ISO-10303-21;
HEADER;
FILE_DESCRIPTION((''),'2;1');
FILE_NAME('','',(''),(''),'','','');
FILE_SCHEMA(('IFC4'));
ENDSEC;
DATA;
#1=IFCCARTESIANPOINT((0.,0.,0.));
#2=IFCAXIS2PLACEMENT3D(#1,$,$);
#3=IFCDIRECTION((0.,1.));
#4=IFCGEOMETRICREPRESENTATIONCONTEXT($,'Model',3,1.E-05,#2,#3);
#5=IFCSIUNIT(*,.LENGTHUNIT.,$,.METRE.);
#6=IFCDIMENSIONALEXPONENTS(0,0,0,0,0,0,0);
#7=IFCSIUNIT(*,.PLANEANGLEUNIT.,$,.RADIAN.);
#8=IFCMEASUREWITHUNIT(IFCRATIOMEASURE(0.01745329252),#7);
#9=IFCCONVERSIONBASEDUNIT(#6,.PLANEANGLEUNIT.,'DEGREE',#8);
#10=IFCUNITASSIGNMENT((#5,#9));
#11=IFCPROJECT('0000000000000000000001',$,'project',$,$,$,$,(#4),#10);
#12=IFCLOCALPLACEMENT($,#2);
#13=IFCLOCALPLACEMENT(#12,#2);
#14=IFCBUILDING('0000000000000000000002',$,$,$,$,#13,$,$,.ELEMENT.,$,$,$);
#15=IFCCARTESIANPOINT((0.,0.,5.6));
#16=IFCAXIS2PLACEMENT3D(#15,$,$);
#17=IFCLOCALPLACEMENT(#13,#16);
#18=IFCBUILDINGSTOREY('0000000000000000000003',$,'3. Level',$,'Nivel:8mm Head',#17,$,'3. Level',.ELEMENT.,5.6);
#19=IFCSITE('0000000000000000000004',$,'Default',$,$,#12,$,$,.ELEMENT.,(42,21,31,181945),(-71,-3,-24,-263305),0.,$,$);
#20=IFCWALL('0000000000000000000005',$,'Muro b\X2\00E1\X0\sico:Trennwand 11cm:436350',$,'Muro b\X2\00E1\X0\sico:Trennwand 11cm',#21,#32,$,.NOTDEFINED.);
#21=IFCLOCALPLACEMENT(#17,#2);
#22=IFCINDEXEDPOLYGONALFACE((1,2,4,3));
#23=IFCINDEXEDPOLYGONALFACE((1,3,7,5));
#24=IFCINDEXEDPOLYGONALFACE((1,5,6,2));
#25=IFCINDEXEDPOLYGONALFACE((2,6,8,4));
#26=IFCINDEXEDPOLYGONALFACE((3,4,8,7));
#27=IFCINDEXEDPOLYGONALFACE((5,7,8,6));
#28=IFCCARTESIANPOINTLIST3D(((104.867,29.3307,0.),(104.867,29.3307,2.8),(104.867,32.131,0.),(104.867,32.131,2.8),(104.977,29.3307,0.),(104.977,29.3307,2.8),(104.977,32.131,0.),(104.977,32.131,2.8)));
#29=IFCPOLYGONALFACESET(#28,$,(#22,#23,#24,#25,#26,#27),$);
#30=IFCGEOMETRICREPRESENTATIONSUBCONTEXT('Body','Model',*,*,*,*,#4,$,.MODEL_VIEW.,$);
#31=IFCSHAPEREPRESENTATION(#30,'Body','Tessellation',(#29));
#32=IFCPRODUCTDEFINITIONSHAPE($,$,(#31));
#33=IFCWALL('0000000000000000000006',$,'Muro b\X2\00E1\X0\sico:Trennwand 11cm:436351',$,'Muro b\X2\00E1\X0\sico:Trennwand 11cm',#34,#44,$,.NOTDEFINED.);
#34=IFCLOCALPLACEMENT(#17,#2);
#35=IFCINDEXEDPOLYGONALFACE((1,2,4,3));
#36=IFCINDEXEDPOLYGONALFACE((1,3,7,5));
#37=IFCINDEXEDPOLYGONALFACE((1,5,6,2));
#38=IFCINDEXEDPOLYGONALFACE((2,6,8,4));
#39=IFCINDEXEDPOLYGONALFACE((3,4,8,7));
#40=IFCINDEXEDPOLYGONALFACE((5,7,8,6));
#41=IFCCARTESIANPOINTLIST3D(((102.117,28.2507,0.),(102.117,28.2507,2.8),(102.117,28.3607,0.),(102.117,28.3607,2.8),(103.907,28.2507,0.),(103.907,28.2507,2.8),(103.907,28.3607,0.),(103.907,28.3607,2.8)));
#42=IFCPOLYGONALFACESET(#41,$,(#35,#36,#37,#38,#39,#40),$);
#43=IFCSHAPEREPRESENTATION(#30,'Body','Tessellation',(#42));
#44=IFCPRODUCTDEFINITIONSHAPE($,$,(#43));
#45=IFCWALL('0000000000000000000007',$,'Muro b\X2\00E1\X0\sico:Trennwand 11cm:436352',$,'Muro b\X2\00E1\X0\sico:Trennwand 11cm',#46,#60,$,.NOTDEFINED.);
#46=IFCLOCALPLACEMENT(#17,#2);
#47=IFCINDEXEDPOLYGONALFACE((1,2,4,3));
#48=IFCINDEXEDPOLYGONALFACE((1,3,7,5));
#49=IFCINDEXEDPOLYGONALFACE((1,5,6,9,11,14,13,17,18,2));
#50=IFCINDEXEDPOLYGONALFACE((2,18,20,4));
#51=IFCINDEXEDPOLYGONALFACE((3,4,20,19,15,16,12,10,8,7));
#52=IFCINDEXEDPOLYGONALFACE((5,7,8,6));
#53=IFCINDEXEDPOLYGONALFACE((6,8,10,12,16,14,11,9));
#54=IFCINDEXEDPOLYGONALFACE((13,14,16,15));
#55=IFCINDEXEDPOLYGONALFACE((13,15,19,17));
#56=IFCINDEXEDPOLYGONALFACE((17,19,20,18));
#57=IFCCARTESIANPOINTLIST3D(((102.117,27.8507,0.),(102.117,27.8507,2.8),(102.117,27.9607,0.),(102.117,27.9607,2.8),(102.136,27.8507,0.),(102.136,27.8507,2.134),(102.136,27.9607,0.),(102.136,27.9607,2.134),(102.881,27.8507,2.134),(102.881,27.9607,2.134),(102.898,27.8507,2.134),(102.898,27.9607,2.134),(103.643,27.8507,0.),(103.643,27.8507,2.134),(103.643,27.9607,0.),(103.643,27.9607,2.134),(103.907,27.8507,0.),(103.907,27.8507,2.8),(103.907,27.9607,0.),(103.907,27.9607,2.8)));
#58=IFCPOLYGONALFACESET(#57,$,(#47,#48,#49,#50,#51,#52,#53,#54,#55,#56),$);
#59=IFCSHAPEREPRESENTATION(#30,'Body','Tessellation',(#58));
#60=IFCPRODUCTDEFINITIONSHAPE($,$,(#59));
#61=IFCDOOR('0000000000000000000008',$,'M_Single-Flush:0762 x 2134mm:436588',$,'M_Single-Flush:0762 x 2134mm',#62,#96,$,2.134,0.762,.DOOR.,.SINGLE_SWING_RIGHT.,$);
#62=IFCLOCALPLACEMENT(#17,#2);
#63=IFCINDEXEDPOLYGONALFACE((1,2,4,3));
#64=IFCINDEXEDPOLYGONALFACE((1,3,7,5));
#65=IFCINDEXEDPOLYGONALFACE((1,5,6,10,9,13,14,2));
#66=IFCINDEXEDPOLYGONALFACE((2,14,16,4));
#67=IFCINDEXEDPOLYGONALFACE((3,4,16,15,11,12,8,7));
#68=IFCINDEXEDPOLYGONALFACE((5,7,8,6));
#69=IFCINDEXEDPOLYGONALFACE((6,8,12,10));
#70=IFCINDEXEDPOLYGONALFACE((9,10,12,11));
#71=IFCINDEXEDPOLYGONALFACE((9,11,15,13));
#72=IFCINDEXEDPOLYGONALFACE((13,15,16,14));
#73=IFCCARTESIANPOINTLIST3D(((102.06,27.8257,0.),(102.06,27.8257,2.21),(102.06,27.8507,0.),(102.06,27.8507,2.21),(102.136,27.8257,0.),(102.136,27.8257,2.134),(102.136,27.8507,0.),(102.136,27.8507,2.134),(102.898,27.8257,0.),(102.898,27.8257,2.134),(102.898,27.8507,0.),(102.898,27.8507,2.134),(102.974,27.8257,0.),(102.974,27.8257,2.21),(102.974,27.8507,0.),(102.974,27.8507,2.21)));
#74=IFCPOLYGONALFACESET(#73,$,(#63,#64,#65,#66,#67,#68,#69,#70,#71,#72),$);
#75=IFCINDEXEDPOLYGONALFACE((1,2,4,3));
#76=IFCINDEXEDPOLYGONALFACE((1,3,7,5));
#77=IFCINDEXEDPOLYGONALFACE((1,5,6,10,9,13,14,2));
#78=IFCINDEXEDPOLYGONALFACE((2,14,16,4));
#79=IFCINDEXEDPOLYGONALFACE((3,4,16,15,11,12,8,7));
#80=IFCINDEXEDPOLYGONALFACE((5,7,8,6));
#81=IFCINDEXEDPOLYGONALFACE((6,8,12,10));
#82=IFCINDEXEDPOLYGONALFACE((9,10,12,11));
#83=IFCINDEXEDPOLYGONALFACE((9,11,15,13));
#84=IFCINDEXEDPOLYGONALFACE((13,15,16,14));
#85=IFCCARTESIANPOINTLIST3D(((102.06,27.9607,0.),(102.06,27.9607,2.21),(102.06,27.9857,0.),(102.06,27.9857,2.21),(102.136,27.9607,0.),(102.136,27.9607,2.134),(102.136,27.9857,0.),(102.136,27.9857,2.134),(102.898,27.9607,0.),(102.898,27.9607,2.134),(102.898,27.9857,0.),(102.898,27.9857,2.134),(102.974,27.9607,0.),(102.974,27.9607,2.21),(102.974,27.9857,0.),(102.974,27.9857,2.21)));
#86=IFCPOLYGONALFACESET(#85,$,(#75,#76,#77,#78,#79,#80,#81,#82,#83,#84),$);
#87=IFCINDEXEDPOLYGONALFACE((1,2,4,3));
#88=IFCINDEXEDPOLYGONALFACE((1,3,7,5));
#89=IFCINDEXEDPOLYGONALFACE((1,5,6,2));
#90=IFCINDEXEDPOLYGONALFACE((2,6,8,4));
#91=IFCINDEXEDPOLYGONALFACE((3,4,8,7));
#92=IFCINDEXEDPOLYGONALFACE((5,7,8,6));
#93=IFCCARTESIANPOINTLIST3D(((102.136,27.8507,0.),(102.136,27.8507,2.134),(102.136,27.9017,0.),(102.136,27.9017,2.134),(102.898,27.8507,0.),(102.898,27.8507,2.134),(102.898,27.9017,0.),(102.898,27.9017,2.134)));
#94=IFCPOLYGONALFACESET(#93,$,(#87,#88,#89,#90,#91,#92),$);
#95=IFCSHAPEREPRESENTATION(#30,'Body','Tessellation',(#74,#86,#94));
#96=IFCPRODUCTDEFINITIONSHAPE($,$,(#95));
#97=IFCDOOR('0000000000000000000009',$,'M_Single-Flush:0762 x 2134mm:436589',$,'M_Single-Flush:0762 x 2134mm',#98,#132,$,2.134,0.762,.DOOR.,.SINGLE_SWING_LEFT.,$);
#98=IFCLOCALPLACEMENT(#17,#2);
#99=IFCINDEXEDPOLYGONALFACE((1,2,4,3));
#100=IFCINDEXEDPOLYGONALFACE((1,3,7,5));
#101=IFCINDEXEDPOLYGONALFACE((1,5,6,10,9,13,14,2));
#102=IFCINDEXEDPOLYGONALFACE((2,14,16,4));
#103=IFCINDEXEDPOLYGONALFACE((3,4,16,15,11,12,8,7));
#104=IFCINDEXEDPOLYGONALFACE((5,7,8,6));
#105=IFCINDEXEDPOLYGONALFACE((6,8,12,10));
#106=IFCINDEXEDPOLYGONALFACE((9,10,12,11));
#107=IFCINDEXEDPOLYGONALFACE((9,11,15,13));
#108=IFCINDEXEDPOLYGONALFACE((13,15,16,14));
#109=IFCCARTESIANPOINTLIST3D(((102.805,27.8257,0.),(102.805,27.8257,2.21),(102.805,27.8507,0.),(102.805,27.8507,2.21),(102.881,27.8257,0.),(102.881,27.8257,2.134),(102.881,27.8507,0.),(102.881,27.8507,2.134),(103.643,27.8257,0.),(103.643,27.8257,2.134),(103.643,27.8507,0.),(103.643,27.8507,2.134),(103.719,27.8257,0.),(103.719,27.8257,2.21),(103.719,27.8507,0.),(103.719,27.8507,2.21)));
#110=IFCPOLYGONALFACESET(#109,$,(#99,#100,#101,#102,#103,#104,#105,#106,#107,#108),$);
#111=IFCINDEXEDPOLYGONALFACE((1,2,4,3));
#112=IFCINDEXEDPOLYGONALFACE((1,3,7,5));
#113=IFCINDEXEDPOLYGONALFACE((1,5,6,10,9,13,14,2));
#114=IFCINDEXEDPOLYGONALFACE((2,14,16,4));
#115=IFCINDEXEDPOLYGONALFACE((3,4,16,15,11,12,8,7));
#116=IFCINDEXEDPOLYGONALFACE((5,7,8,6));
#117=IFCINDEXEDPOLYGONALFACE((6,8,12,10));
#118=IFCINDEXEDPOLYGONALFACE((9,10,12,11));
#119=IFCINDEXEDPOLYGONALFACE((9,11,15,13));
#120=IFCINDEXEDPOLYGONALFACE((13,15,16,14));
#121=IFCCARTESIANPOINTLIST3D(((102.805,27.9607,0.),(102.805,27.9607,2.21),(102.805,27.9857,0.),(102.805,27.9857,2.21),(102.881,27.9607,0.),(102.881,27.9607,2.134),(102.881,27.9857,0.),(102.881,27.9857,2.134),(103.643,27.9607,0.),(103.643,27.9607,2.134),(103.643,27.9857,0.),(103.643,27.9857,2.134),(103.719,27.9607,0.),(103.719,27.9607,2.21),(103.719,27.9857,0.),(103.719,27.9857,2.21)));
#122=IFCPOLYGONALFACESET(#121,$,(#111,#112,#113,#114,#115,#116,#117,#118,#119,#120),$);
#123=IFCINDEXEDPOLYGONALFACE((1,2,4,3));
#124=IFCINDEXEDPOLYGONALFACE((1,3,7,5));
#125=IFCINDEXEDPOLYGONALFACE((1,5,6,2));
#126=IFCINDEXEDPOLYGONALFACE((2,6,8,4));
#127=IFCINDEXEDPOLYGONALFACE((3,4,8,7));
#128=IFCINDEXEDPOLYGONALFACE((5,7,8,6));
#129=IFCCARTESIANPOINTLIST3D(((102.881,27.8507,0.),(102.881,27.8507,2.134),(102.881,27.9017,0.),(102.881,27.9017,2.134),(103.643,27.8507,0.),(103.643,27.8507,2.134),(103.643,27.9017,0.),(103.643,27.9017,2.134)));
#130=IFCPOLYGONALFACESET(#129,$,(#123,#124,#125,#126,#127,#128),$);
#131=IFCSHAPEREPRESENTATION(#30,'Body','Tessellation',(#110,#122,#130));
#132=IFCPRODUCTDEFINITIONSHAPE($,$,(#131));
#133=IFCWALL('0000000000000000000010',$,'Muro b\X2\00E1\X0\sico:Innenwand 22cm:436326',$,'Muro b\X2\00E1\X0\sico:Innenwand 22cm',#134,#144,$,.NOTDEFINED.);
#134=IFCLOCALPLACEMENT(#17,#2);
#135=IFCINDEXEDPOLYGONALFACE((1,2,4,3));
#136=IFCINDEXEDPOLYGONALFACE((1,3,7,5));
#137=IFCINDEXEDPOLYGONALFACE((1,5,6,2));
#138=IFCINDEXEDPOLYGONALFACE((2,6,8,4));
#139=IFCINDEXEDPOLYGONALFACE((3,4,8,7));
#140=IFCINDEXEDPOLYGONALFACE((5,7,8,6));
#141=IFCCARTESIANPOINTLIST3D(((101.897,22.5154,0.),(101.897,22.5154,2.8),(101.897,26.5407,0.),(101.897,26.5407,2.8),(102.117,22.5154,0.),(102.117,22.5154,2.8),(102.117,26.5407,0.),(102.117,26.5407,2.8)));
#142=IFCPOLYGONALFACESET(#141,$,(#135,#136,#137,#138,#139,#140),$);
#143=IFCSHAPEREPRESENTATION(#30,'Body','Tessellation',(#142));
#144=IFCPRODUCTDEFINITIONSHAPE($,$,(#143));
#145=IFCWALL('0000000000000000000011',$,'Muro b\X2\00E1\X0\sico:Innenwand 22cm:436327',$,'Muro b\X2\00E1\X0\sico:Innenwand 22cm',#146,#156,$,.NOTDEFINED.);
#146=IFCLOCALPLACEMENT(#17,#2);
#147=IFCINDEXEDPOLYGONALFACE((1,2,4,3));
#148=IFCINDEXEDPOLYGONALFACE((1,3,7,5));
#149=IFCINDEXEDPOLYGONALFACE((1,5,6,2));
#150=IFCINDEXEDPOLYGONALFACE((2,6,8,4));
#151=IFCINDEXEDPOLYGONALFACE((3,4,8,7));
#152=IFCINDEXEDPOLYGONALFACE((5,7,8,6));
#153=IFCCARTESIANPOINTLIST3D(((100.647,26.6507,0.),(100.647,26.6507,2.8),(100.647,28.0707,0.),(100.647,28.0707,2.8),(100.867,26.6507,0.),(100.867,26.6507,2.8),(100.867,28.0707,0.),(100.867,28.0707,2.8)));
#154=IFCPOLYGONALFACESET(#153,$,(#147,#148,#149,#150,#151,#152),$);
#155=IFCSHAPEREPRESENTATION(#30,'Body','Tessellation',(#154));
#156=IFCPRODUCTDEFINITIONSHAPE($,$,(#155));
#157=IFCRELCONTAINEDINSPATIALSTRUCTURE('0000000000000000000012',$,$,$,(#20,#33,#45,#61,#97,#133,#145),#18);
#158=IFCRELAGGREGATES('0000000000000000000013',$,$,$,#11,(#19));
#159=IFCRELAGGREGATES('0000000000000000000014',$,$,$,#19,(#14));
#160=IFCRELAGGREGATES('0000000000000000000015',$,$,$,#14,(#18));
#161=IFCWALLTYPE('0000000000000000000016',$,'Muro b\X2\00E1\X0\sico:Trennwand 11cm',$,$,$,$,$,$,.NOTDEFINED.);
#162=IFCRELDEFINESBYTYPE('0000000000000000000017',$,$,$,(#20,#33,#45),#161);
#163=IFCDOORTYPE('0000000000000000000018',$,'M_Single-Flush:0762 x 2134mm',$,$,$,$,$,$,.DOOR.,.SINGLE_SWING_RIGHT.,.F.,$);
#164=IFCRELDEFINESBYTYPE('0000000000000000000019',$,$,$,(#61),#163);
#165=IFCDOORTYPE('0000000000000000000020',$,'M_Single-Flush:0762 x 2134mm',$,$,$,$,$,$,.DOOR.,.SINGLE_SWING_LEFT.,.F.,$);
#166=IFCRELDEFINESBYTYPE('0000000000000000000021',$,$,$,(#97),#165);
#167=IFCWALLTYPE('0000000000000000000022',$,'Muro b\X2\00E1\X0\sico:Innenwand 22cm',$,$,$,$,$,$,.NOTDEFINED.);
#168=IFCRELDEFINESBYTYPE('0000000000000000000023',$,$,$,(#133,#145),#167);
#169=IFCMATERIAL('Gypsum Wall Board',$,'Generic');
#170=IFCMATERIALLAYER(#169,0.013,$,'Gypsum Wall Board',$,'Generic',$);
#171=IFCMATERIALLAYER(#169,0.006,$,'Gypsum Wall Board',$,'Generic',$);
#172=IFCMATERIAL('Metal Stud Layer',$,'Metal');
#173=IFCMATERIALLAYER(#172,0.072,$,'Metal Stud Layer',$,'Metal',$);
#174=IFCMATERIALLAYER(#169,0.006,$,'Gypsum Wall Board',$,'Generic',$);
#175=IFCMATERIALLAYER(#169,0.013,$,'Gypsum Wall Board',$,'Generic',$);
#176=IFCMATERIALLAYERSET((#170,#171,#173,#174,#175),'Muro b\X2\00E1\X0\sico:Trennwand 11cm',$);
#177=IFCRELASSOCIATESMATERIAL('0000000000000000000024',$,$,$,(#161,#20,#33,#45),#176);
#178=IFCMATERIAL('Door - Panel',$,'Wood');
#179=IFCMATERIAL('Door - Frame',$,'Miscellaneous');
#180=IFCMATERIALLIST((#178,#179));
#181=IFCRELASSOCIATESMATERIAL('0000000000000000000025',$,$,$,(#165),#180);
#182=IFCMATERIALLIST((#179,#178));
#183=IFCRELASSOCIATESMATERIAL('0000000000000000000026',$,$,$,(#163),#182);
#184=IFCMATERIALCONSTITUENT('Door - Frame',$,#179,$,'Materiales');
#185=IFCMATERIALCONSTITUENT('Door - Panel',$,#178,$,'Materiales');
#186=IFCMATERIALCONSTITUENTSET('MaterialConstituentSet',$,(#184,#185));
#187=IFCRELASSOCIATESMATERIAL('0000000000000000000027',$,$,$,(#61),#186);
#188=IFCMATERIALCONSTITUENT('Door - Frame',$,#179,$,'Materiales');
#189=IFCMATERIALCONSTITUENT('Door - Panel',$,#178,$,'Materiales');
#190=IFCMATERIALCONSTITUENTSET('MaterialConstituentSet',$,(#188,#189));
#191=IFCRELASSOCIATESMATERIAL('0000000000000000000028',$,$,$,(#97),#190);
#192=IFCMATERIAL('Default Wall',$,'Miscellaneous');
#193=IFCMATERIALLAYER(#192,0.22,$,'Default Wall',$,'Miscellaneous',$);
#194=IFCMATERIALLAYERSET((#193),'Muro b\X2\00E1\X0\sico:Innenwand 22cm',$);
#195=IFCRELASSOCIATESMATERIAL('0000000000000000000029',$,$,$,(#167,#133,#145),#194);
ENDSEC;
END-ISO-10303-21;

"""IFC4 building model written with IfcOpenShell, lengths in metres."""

from ifc_helpers import new_model, entity, si_unit, converted_unit, direction, frame, frame_2d, origin, origin_2d_with_axis, place, context, subcontext, project, spatial, polyline, rectangle, outline, extrude, source, transform, mapped, material, material_list, layer, layer_set, layer_usage, constituent, constituent_set, type_object, type_shapes, element, fill, save


model = new_model("IFC4")

# Units and contexts
model_context = context("Model", 3, precision=1e-05, world=origin(), true_north=direction((0.0, 1.0)))
body_context = subcontext(model_context, "Body", "Model", "MODEL_VIEW")
ifc_project = project(units=[si_unit("LENGTHUNIT", "METRE"), converted_unit("PLANEANGLEUNIT", "DEGREE", entity("IfcRatioMeasure", 0.01745329252), si_unit("PLANEANGLEUNIT", "RADIAN"), dimensions=[0, 0, 0, 0, 0, 0, 0])], contexts=[model_context])

# Site, building, storey
site_placement = place(None, origin())
site = spatial("IfcSite", under=ifc_project, at=site_placement, Name="Default", CompositionType="ELEMENT", RefLatitude=(42, 21, 31, 181945), RefLongitude=(-71, -3, -24, -263305), RefElevation=0.0)
building_placement = place(site_placement, origin())
building = spatial("IfcBuilding", under=site, at=building_placement, CompositionType="ELEMENT")
storey_placement = place(building_placement, frame((0.0, 0.0, 5.6)))
storey = spatial("IfcBuildingStorey", under=building, at=storey_placement, Name="3. Level", ObjectType="Nivel:8mm Head", LongName="3. Level", CompositionType="ELEMENT", Elevation=5.6)

# Shared definitions
ifc_material_1 = material(Name="Gypsum Wall Board", Category="Generic")
ifc_layer_1 = layer(ifc_material_1, 0.013, Name="Gypsum Wall Board", Category="Generic")
ifc_layer_2 = layer(ifc_material_1, 0.006, Name="Gypsum Wall Board", Category="Generic")
ifc_material_2 = material(Name="Metal Stud Layer", Category="Metal")
ifc_layer_3 = layer(ifc_material_2, 0.072, Name="Metal Stud Layer", Category="Metal")
ifc_layer_4 = layer(ifc_material_1, 0.006, Name="Gypsum Wall Board", Category="Generic")
ifc_layer_5 = layer(ifc_material_1, 0.013, Name="Gypsum Wall Board", Category="Generic")
ifc_layer_set_1 = layer_set([ifc_layer_1, ifc_layer_2, ifc_layer_3, ifc_layer_4, ifc_layer_5], Name="Muro básico:Trennwand 11cm")
wall_type_1 = type_object("IfcWallType", Name="Muro básico:Trennwand 11cm", PredefinedType="NOTDEFINED", material=ifc_layer_set_1)
ifc_material_3 = material(Name="Door - Frame", Category="Miscellaneous")

# Shared definitions
ifc_material_4 = material(Name="Door - Panel", Category="Wood")
ifc_material_list_1 = material_list([ifc_material_4, ifc_material_3])
door_type_1 = type_object("IfcDoorType", Name="M_Single-Flush:0762 x 2134mm", OperationType="SINGLE_SWING_LEFT", ParameterTakesPrecedence=False, PredefinedType="DOOR", material=ifc_material_list_1)
shared_shape_1 = source(origin(), body_context, "Body", "SweptSolid", [
    extrude(outline(polyline([(-0.457, -1.124), (0.457, -1.124), (0.457, 1.086), (0.381, 1.086), (0.381, -1.048), (-0.381, -1.048), (-0.381, 1.086), (-0.457, 1.086), (-0.457, -1.124)])), frame((0.381, 0.135, 1.086), z_axis=(0.0, -1.0, 0.0), x_axis=(-1.0, 0.0, 0.0)), (0.0, 0.0, 1.0), 0.025),
    extrude(outline(polyline([(-1.124, -0.457), (1.086, -0.457), (1.086, -0.381), (-1.048, -0.381), (-1.048, 0.381), (1.086, 0.381), (1.086, 0.457), (-1.124, 0.457), (-1.124, -0.457)])), frame((0.381, 0.0, 1.086), z_axis=(0.0, -1.0, 0.0), x_axis=(0.0, 0.0, -1.0)), (0.0, 0.0, 1.0), 0.025),
    extrude(rectangle(XDim=0.762, YDim=0.051, at=origin_2d_with_axis()), frame((0.381, 0.0845, 0.0)), (0.0, 0.0, 1.0), 2.134),
])
type_shapes(door_type_1, [shared_shape_1])

# Walls
ifc_layer_usage_1 = layer_usage(ifc_layer_set_1, "AXIS2", "NEGATIVE", 0.055)
wall_1_placement = place(storey_placement, frame((104.922, 32.131, 0.0), z_axis=(0.0, 0.0, 1.0), x_axis=(0.0, -1.0, 0.0)))
element("IfcWall", 1, at=wall_1_placement, inside=storey, type_object=wall_type_1, material=ifc_layer_usage_1, Name="Muro básico:Trennwand 11cm:436350", ObjectType="Muro básico:Trennwand 11cm", PredefinedType="NOTDEFINED", context=body_context, shape_type="SweptSolid", body=[
    extrude(rectangle(XDim=2.8003, YDim=0.11, at=frame_2d((1.4002, 0.0), x_axis=(-1.0, 0.0))), origin(), (0.0, 0.0, 1.0), 2.8),
])
ifc_layer_usage_2 = layer_usage(ifc_layer_set_1, "AXIS2", "NEGATIVE", 0.055)
wall_2_placement = place(storey_placement, frame((103.907, 28.3057, 0.0), z_axis=(0.0, 0.0, 1.0), x_axis=(-1.0, 0.0, 0.0)))
element("IfcWall", 2, at=wall_2_placement, inside=storey, type_object=wall_type_1, material=ifc_layer_usage_2, Name="Muro básico:Trennwand 11cm:436351", ObjectType="Muro básico:Trennwand 11cm", PredefinedType="NOTDEFINED", context=body_context, shape_type="SweptSolid", body=[
    extrude(rectangle(XDim=1.79, YDim=0.11, at=frame_2d((0.895, 0.0), x_axis=(-1.0, 0.0))), origin(), (0.0, 0.0, 1.0), 2.8),
])

# Wall, openings, doors
ifc_layer_usage_3 = layer_usage(ifc_layer_set_1, "AXIS2", "NEGATIVE", 0.055)
wall_3_placement = place(storey_placement, frame((103.907, 27.9057, 0.0), z_axis=(0.0, 0.0, 1.0), x_axis=(-1.0, 0.0, 0.0)))
wall_3 = element("IfcWall", 3, at=wall_3_placement, inside=storey, type_object=wall_type_1, material=ifc_layer_usage_3, Name="Muro básico:Trennwand 11cm:436352", ObjectType="Muro básico:Trennwand 11cm", PredefinedType="NOTDEFINED", context=body_context, shape_type="SweptSolid", body=[
    extrude(rectangle(XDim=1.79, YDim=0.11, at=frame_2d((0.895, 0.0), x_axis=(-1.0, 0.0))), origin(), (0.0, 0.0, 1.0), 2.8),
])
opening_1_placement = place(wall_3_placement, frame((1.009, -0.055, 0.0)))
opening_1 = element("IfcOpeningElement", 4, at=opening_1_placement, cuts=wall_3, ObjectType="Opening", PredefinedType="OPENING", context=body_context, shape_type="SweptSolid", body=[
    extrude(rectangle(XDim=0.762, YDim=2.134, at=frame_2d((1.067, 0.381), x_axis=(0.0, 1.0))), frame((0.0, 0.0, 0.0), z_axis=(0.0, 1.0, 0.0), x_axis=(0.0, 0.0, 1.0)), (0.0, 0.0, 1.0), 0.11),
])
opening_2_placement = place(wall_3_placement, frame((0.264, -0.055, 0.0)))
opening_2 = element("IfcOpeningElement", 5, at=opening_2_placement, cuts=wall_3, ObjectType="Opening", PredefinedType="OPENING", context=body_context, shape_type="SweptSolid", body=[
    extrude(rectangle(XDim=0.762, YDim=2.134, at=frame_2d((1.067, 0.381), x_axis=(0.0, -1.0))), frame((0.0, 0.0, 0.0), z_axis=(0.0, 1.0, 0.0), x_axis=(0.0, 0.0, 1.0)), (0.0, 0.0, 1.0), 0.11),
])
ifc_constituent_1 = constituent(ifc_material_3, Name="Door - Frame", Category="Materiales")
ifc_constituent_2 = constituent(ifc_material_4, Name="Door - Panel", Category="Materiales")
ifc_constituent_set_1 = constituent_set(constituents=[ifc_constituent_1, ifc_constituent_2], Name="MaterialConstituentSet")
ifc_material_list_2 = material_list([ifc_material_3, ifc_material_4])
door_type_2 = type_object("IfcDoorType", Name="M_Single-Flush:0762 x 2134mm", OperationType="SINGLE_SWING_RIGHT", ParameterTakesPrecedence=False, PredefinedType="DOOR", material=ifc_material_list_2)
shared_shape_2 = source(origin(), body_context, "Body", "SweptSolid", [
    extrude(outline(polyline([(-0.457, -1.124), (0.457, -1.124), (0.457, 1.086), (0.381, 1.086), (0.381, -1.048), (-0.381, -1.048), (-0.381, 1.086), (-0.457, 1.086), (-0.457, -1.124)])), frame((0.381, 0.11, 1.086), z_axis=(0.0, 1.0, 0.0), x_axis=(1.0, 0.0, 0.0)), (0.0, 0.0, 1.0), 0.025),
    extrude(outline(polyline([(-1.124, -0.457), (1.086, -0.457), (1.086, -0.381), (-1.048, -0.381), (-1.048, 0.381), (1.086, 0.381), (1.086, 0.457), (-1.124, 0.457), (-1.124, -0.457)])), frame((0.381, -0.025, 1.086), z_axis=(0.0, 1.0, 0.0), x_axis=(0.0, 0.0, -1.0)), (0.0, 0.0, 1.0), 0.025),
    extrude(rectangle(XDim=0.051, YDim=0.762, at=origin_2d_with_axis()), frame((0.381, 0.0845, 0.0), z_axis=(0.0, 0.0, 1.0), x_axis=(0.0, 1.0, 0.0)), (0.0, 0.0, 1.0), 2.134),
])
type_shapes(door_type_2, [shared_shape_2])
door_1_placement = place(opening_1_placement, origin())
door_1 = element("IfcDoor", 6, at=door_1_placement, inside=storey, type_object=door_type_2, material=ifc_constituent_set_1, Name="M_Single-Flush:0762 x 2134mm:436588", ObjectType="M_Single-Flush:0762 x 2134mm", OperationType="SINGLE_SWING_RIGHT", OverallHeight=2.134, OverallWidth=0.762, PredefinedType="DOOR", context=body_context, shape_type="MappedRepresentation", body=[
    mapped(shared_shape_2, transform((0.0, 0.0, 0.0), scale=1.0)),
])
fill(opening_1, door_1)
ifc_constituent_3 = constituent(ifc_material_3, Name="Door - Frame", Category="Materiales")
ifc_constituent_4 = constituent(ifc_material_4, Name="Door - Panel", Category="Materiales")
ifc_constituent_set_2 = constituent_set(constituents=[ifc_constituent_3, ifc_constituent_4], Name="MaterialConstituentSet")
door_2_placement = place(opening_2_placement, origin())
door_2 = element("IfcDoor", 7, at=door_2_placement, inside=storey, type_object=door_type_1, material=ifc_constituent_set_2, Name="M_Single-Flush:0762 x 2134mm:436589", ObjectType="M_Single-Flush:0762 x 2134mm", OperationType="SINGLE_SWING_LEFT", OverallHeight=2.134, OverallWidth=0.762, PredefinedType="DOOR", context=body_context, shape_type="MappedRepresentation", body=[
    mapped(shared_shape_1, transform((0.0, 0.0, 0.0), scale=1.0)),
])
fill(opening_2, door_2)

# Walls
ifc_material_5 = material(Name="Default Wall", Category="Miscellaneous")
ifc_layer_6 = layer(ifc_material_5, 0.22, Name="Default Wall", Category="Miscellaneous")
ifc_layer_set_2 = layer_set([ifc_layer_6], Name="Muro básico:Innenwand 22cm")
ifc_layer_usage_4 = layer_usage(ifc_layer_set_2, "AXIS2", "NEGATIVE", 0.11)
wall_type_2 = type_object("IfcWallType", Name="Muro básico:Innenwand 22cm", PredefinedType="NOTDEFINED", material=ifc_layer_set_2)
wall_4_placement = place(storey_placement, frame((102.007, 22.5154, 0.0), z_axis=(0.0, 0.0, 1.0), x_axis=(0.0, 1.0, 0.0)))
element("IfcWall", 8, at=wall_4_placement, inside=storey, type_object=wall_type_2, material=ifc_layer_usage_4, Name="Muro básico:Innenwand 22cm:436326", ObjectType="Muro básico:Innenwand 22cm", PredefinedType="NOTDEFINED", context=body_context, shape_type="SweptSolid", body=[
    extrude(rectangle(XDim=4.0253, YDim=0.22, at=frame_2d((2.0127, 0.0), x_axis=(-1.0, 0.0))), origin(), (0.0, 0.0, 1.0), 2.8),
])
ifc_layer_usage_5 = layer_usage(ifc_layer_set_2, "AXIS2", "NEGATIVE", 0.11)
wall_5_placement = place(storey_placement, frame((100.757, 26.6507, 0.0), z_axis=(0.0, 0.0, 1.0), x_axis=(0.0, 1.0, 0.0)))
element("IfcWall", 9, at=wall_5_placement, inside=storey, type_object=wall_type_2, material=ifc_layer_usage_5, Name="Muro básico:Innenwand 22cm:436327", ObjectType="Muro básico:Innenwand 22cm", PredefinedType="NOTDEFINED", context=body_context, shape_type="SweptSolid", body=[
    extrude(rectangle(XDim=1.42, YDim=0.22, at=frame_2d((0.71, 0.0), x_axis=(-1.0, 0.0))), origin(), (0.0, 0.0, 1.0), 2.8),
])

save(model, "model.ifc")
